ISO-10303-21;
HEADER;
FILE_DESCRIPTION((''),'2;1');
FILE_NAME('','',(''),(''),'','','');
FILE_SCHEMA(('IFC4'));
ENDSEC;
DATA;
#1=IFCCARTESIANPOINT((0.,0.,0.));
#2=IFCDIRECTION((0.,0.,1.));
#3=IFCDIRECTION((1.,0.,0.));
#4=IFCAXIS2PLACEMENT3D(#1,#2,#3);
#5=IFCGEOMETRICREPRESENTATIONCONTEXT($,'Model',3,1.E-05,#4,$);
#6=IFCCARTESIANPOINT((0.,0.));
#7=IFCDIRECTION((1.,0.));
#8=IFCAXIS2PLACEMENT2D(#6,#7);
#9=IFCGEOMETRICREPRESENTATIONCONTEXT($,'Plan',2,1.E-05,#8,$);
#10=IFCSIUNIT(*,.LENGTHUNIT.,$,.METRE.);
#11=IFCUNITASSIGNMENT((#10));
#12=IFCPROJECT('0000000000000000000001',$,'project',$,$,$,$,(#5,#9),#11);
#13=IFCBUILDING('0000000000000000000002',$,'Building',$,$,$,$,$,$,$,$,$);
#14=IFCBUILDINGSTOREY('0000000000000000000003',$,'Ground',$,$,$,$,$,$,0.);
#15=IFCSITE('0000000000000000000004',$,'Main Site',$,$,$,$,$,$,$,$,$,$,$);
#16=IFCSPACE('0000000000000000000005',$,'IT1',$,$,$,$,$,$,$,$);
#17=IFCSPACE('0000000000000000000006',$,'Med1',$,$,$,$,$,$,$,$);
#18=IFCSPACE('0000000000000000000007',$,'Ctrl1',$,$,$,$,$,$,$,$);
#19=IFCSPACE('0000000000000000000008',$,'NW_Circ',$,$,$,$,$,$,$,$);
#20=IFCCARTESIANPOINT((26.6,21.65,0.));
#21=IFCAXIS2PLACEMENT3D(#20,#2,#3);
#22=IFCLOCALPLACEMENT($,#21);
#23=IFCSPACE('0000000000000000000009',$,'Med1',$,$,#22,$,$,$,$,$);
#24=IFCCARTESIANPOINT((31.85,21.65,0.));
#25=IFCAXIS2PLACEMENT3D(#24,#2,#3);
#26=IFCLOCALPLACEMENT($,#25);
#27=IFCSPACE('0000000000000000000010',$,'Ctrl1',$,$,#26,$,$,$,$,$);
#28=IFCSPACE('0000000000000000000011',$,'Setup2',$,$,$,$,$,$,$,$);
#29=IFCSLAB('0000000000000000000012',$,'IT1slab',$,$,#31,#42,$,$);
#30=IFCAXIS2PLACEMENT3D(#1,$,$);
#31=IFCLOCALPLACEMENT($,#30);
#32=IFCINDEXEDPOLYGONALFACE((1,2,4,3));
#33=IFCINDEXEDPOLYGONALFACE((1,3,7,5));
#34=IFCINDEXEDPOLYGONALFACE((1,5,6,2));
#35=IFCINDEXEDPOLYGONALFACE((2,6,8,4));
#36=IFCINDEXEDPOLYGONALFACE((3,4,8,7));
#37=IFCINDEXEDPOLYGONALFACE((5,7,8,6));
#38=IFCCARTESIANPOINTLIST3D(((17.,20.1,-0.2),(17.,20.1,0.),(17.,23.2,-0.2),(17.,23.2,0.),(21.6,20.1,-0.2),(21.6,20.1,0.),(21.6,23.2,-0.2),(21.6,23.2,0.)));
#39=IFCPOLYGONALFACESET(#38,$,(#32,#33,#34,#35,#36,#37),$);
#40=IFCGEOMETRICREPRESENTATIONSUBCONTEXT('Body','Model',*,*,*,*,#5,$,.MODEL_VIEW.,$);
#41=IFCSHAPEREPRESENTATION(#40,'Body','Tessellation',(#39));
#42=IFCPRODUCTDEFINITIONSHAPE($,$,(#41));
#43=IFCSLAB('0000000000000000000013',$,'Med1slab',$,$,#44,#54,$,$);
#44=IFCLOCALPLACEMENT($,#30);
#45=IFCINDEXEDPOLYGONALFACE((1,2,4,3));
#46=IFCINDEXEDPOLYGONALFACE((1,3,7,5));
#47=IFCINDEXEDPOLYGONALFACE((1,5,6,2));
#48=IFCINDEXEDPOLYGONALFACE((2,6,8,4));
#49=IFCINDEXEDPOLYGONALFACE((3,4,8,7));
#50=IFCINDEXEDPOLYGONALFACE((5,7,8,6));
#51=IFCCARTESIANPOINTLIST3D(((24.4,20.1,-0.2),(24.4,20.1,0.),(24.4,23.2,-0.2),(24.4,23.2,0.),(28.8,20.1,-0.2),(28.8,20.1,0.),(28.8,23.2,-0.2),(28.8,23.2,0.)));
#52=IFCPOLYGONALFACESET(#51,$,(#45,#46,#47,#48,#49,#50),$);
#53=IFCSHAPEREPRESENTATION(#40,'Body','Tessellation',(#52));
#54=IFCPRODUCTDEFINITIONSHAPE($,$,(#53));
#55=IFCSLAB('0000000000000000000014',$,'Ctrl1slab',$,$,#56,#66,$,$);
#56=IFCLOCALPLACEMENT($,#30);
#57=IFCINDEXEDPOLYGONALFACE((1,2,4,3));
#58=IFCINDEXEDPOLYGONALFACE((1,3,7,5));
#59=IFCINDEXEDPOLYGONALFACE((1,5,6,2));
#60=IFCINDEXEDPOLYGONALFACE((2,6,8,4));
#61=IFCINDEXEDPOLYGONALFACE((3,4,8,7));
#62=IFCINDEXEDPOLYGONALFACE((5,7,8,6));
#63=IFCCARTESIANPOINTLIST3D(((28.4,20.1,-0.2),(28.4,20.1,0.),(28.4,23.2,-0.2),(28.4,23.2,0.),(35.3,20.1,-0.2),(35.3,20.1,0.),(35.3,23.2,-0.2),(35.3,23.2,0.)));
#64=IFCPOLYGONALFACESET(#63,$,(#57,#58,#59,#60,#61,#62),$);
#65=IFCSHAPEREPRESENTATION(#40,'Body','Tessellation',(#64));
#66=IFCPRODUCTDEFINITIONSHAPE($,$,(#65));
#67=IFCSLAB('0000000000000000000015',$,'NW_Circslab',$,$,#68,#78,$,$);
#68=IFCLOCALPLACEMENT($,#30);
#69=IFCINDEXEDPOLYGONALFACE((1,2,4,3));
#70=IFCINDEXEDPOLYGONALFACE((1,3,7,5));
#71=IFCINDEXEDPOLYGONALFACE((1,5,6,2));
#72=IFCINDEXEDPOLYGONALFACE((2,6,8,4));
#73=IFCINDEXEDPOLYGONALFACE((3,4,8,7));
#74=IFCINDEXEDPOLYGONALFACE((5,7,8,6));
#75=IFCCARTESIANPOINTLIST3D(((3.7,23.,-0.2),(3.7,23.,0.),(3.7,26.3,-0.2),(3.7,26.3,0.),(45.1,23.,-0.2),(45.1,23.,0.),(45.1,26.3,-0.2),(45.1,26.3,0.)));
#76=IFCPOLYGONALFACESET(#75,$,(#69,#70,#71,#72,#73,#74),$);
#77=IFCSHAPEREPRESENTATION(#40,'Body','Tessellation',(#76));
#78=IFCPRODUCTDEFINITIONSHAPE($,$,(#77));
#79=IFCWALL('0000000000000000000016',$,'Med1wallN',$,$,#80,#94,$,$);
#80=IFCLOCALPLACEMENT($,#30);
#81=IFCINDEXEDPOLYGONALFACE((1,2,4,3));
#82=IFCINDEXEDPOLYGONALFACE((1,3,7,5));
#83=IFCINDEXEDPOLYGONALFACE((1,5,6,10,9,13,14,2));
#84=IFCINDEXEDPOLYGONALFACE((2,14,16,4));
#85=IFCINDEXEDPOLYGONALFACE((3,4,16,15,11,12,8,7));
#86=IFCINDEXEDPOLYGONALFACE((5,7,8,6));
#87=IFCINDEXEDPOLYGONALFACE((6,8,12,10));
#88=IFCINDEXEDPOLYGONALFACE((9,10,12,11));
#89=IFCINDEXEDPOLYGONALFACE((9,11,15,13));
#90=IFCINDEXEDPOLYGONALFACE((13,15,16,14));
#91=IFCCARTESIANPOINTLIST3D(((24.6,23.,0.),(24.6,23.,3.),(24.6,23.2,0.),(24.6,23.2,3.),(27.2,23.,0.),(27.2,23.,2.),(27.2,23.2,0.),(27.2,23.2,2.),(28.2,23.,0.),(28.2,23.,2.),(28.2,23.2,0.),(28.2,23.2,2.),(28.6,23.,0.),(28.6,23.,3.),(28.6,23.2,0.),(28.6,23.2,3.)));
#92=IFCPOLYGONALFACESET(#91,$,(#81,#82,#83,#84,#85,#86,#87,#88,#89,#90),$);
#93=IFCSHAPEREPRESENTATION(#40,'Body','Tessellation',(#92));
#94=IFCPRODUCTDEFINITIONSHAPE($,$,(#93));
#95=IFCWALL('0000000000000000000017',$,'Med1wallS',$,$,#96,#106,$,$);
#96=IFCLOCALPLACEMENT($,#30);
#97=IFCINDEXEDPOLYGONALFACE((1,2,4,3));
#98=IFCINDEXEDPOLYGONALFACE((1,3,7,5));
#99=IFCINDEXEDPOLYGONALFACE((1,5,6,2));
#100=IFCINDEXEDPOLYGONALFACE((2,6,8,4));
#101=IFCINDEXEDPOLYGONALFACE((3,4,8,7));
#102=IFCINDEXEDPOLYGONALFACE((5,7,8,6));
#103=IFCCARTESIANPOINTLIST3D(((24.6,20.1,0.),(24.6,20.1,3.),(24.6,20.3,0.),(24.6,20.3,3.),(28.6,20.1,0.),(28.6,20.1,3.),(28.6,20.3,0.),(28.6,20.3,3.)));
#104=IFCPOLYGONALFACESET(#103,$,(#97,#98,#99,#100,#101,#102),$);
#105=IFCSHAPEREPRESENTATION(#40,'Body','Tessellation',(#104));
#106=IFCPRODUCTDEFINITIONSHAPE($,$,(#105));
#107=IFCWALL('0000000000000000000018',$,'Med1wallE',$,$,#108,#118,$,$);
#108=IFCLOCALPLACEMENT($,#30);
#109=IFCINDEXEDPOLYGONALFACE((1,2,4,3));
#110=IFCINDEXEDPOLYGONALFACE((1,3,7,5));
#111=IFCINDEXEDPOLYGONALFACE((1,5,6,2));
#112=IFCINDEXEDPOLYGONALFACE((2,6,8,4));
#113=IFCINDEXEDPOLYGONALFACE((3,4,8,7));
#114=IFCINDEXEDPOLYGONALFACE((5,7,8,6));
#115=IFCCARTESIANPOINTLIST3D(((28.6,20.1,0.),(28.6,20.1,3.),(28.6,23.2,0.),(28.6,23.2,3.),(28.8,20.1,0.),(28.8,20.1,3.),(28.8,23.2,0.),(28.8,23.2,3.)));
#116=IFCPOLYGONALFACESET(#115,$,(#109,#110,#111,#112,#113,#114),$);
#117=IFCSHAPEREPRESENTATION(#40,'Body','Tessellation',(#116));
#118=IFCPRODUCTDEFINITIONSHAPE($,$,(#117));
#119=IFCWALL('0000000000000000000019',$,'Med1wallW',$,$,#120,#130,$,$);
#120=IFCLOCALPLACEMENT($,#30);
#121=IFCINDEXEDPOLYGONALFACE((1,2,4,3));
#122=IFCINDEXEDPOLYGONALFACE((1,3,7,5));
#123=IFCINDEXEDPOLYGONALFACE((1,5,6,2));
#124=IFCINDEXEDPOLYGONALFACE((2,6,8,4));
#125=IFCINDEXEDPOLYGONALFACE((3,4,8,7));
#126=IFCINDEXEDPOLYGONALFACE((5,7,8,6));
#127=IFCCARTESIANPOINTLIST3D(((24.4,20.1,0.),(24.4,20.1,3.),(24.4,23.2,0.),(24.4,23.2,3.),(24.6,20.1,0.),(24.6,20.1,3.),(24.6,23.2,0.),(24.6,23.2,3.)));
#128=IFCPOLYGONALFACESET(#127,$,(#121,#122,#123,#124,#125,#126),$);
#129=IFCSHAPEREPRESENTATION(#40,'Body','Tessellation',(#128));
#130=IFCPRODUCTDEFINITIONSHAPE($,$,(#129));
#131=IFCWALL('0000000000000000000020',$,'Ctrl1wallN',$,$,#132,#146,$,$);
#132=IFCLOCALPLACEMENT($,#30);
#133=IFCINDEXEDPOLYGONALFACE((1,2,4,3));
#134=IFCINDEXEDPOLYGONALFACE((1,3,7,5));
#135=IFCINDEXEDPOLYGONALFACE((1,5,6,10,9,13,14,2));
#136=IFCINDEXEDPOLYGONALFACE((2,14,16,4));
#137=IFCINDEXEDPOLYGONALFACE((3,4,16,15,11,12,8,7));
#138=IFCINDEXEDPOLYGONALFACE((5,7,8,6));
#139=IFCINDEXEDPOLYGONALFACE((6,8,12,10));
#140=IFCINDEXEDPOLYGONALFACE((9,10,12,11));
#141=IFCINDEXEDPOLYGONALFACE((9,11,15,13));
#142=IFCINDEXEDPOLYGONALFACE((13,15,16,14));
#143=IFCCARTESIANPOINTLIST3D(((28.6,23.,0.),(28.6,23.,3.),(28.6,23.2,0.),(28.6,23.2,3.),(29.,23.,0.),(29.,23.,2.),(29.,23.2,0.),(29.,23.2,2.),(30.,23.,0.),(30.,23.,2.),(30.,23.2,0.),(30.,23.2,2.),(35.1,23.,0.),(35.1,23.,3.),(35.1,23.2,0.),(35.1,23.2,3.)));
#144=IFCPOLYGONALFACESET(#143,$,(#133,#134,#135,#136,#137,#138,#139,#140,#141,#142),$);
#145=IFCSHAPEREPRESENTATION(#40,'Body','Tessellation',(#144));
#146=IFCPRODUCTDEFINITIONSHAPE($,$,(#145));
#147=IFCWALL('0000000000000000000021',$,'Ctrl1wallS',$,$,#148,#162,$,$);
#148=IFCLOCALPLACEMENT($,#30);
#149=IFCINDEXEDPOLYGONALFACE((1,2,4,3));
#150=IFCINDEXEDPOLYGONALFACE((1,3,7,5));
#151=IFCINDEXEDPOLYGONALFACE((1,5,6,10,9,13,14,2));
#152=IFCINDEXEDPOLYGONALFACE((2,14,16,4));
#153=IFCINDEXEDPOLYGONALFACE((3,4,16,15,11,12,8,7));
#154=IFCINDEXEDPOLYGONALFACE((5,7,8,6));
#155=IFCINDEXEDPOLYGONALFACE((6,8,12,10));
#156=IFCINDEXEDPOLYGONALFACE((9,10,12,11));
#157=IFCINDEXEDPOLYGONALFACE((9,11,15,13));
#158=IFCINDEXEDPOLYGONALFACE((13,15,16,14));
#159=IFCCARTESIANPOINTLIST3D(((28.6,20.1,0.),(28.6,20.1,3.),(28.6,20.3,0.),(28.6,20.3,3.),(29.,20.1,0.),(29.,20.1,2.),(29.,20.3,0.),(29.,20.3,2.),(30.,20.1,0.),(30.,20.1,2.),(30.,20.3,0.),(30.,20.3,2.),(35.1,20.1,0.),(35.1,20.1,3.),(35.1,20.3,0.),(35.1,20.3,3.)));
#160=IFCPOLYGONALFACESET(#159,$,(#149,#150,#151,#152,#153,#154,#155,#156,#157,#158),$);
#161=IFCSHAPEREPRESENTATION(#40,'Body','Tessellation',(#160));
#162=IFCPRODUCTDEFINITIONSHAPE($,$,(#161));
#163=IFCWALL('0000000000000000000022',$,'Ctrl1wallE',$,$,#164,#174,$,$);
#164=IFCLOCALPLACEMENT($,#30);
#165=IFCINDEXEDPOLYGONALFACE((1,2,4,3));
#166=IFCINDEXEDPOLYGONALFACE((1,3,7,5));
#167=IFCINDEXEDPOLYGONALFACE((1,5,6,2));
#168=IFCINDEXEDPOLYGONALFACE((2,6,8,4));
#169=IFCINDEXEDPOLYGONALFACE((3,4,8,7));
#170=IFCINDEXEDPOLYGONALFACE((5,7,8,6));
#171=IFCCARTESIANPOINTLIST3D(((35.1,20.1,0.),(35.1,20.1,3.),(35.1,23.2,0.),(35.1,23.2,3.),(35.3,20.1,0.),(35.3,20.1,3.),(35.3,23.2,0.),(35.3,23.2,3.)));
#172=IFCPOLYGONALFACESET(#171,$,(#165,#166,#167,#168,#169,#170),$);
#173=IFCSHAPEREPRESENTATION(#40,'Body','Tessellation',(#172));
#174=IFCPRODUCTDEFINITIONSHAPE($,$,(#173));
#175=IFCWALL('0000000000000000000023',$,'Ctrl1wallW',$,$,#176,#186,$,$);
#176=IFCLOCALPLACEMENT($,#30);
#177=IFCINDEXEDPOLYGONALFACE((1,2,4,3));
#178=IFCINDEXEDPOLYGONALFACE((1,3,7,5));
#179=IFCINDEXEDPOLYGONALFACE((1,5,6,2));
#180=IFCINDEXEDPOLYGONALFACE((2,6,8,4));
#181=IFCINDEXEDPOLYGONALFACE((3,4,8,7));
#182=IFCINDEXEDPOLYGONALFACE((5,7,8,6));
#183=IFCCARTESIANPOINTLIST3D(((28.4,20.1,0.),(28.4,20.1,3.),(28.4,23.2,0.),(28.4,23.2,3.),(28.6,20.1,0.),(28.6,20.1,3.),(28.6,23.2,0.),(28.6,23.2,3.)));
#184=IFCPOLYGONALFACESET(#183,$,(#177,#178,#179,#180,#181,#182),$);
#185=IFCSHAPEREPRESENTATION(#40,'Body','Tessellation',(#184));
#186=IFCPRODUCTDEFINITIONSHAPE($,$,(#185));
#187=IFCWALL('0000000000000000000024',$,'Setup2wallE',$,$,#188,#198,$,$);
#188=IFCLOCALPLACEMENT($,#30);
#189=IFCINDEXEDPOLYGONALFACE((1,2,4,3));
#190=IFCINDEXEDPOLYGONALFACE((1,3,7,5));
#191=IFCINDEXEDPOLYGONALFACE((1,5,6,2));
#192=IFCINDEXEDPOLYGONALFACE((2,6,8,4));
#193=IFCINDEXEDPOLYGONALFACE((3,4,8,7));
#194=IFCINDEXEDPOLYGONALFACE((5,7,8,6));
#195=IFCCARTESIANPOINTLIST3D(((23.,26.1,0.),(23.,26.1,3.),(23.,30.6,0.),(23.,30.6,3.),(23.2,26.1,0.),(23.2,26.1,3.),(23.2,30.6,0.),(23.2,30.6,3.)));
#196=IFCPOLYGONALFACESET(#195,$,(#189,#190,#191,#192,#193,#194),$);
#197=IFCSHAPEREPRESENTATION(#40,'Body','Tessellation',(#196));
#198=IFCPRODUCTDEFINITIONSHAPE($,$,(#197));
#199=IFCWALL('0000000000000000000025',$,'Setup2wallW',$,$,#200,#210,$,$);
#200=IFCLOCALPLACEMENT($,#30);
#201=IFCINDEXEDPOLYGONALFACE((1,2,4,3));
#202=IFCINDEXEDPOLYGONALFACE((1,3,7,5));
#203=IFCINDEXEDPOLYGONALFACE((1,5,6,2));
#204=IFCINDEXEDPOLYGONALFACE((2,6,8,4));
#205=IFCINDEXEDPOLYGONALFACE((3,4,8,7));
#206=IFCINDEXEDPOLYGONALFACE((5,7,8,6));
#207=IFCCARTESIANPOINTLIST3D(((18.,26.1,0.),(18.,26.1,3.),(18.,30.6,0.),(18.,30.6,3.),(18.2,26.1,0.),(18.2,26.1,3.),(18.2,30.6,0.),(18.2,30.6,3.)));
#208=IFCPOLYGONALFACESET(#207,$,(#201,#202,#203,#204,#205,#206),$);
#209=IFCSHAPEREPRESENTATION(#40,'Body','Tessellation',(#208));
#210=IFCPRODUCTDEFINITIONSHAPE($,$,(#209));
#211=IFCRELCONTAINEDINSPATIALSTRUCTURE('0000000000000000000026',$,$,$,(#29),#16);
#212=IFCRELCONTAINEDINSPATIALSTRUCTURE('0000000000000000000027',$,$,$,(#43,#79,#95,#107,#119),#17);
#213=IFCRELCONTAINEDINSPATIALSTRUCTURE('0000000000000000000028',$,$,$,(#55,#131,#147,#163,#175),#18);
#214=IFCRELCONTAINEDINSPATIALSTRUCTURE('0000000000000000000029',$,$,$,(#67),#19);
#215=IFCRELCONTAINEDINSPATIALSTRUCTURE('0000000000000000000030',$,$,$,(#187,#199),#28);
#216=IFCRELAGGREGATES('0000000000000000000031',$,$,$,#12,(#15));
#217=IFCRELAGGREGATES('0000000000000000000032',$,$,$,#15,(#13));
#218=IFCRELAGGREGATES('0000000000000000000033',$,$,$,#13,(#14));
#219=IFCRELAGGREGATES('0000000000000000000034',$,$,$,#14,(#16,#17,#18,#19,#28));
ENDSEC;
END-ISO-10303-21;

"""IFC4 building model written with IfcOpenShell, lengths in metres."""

from ifc_helpers import new_model, si_unit, frame, origin_with_axes, origin_2d_with_axis, place, context, subcontext, project, spatial, indexed_curve, rectangle, outline, extrude, element, save


model = new_model("IFC4")

# Units and contexts
model_context = context("Model", 3, precision=1e-05, world=origin_with_axes())
plan_context = context("Plan", 2, precision=1e-05, world=origin_2d_with_axis())
body_context = subcontext(model_context, "Body", "Model", "MODEL_VIEW")
ifc_project = project(units=[si_unit("LENGTHUNIT", "METRE")], contexts=[model_context, plan_context])

# Site, building, storey, space
site = spatial("IfcSite", under=ifc_project, Name="Main Site")
building = spatial("IfcBuilding", under=site, Name="Building")
storey = spatial("IfcBuildingStorey", under=building, Name="Ground", Elevation=0.0)
space_1 = spatial("IfcSpace", under=storey, Name="IT1")

# Slab
slab_1_placement = place(None, frame((19.3, 21.65, -0.2), z_axis=(0.0, 0.0, 1.0), x_axis=(1.0, 0.0, 0.0)))
element("IfcSlab", 1, at=slab_1_placement, inside=space_1, Name="IT1slab", context=body_context, shape_type="SweptSolid", body=[
    extrude(rectangle(XDim=4.6, YDim=3.1), origin_with_axes(), (0.0, 0.0, 1.0), 0.2),
])

# Shared definitions
space_2 = spatial("IfcSpace", under=storey, Name="Med1")

# Slab
slab_2_placement = place(None, frame((26.6, 21.65, -0.2), z_axis=(0.0, 0.0, 1.0), x_axis=(1.0, 0.0, 0.0)))
element("IfcSlab", 2, at=slab_2_placement, inside=space_2, Name="Med1slab", context=body_context, shape_type="SweptSolid", body=[
    extrude(rectangle(XDim=4.4, YDim=3.1), origin_with_axes(), (0.0, 0.0, 1.0), 0.2),
])

# Shared definitions
space_3 = spatial("IfcSpace", under=storey, Name="Ctrl1")

# Slab
slab_3_placement = place(None, frame((31.85, 21.65, -0.2), z_axis=(0.0, 0.0, 1.0), x_axis=(1.0, 0.0, 0.0)))
element("IfcSlab", 3, at=slab_3_placement, inside=space_3, Name="Ctrl1slab", context=body_context, shape_type="SweptSolid", body=[
    extrude(rectangle(XDim=6.9, YDim=3.1), origin_with_axes(), (0.0, 0.0, 1.0), 0.2),
])

# Shared definitions
space_4 = spatial("IfcSpace", under=storey, Name="NW_Circ")

# Slab
slab_4_placement = place(None, frame((24.4, 24.65, -0.2), z_axis=(0.0, 0.0, 1.0), x_axis=(1.0, 0.0, 0.0)))
element("IfcSlab", 4, at=slab_4_placement, inside=space_4, Name="NW_Circslab", context=body_context, shape_type="SweptSolid", body=[
    extrude(rectangle(XDim=41.4, YDim=3.3), origin_with_axes(), (0.0, 0.0, 1.0), 0.2),
])

# Wall
wall_1_placement = place(None, frame((24.6, 23.0, 0.0), z_axis=(0.0, 0.0, 1.0), x_axis=(1.0, 0.0, 0.0)))
wall_1 = element("IfcWall", 5, at=wall_1_placement, inside=space_2, Name="Med1wallN", context=body_context, shape_type="SweptSolid", body=[
    extrude(outline(indexed_curve([(0.0, 0.0), (0.0, 0.2), (4.0, 0.2), (4.0, 0.0), (0.0, 0.0)], self_intersect=False)), origin_with_axes(), (0.0, 0.0, 1.0), 3.0),
])

# Shared definitions
space_5_placement = place(None, frame((26.6, 21.65, 0.0), z_axis=(0.0, 0.0, 1.0), x_axis=(1.0, 0.0, 0.0)))
space_5 = spatial("IfcSpace", at=space_5_placement, Name="Med1")

# Opening
opening_1_placement = place(wall_1_placement, frame((2.6, 0.0, 0.0), z_axis=(0.0, 0.0, 1.0), x_axis=(1.0, 0.0, 0.0)))
element("IfcOpeningElement", 6, at=opening_1_placement, inside=space_5, cuts=wall_1, context=body_context, shape_type="SweptSolid", body=[
    extrude(outline(indexed_curve([(0.0, 0.0), (0.0, 0.4), (1.0, 0.4), (1.0, 0.0), (0.0, 0.0)], self_intersect=False)), origin_with_axes(), (0.0, 0.0, 1.0), 2.0),
])

# Walls
wall_2_placement = place(None, frame((24.6, 20.1, 0.0), z_axis=(0.0, 0.0, 1.0), x_axis=(1.0, 0.0, 0.0)))
element("IfcWall", 7, at=wall_2_placement, inside=space_2, Name="Med1wallS", context=body_context, shape_type="SweptSolid", body=[
    extrude(outline(indexed_curve([(0.0, 0.0), (0.0, 0.2), (4.0, 0.2), (4.0, 0.0), (0.0, 0.0)], self_intersect=False)), origin_with_axes(), (0.0, 0.0, 1.0), 3.0),
])
for number, where, z_axis, x_axis, name in (
    (8, (28.8, 20.1, 0.0), (0.0, 0.0, 1.0), (0.0, 1.0, 0.0), "Med1wallE"),
    (9, (24.6, 20.1, 0.0), (0.0, 0.0, 1.0), (0.0, 1.0, 0.0), "Med1wallW"),
):
    element("IfcWall", number, at=place(None, frame(where, z_axis=z_axis, x_axis=x_axis)), inside=space_2, Name=name, context=body_context, shape_type="SweptSolid", body=[
        extrude(outline(indexed_curve([(0.0, 0.0), (0.0, 0.2), (3.1, 0.2), (3.1, 0.0), (0.0, 0.0)], self_intersect=False)), origin_with_axes(), (0.0, 0.0, 1.0), 3.0),
    ])

# Wall
wall_3_placement = place(None, frame((28.6, 23.0, 0.0), z_axis=(0.0, 0.0, 1.0), x_axis=(1.0, 0.0, 0.0)))
wall_3 = element("IfcWall", 10, at=wall_3_placement, inside=space_3, Name="Ctrl1wallN", context=body_context, shape_type="SweptSolid", body=[
    extrude(outline(indexed_curve([(0.0, 0.0), (0.0, 0.2), (6.5, 0.2), (6.5, 0.0), (0.0, 0.0)], self_intersect=False)), origin_with_axes(), (0.0, 0.0, 1.0), 3.0),
])

# Shared definitions
space_6_placement = place(None, frame((31.85, 21.65, 0.0), z_axis=(0.0, 0.0, 1.0), x_axis=(1.0, 0.0, 0.0)))
space_6 = spatial("IfcSpace", at=space_6_placement, Name="Ctrl1")

# Opening
opening_2_placement = place(wall_3_placement, frame((0.4, 0.0, 0.0), z_axis=(0.0, 0.0, 1.0), x_axis=(1.0, 0.0, 0.0)))
element("IfcOpeningElement", 11, at=opening_2_placement, inside=space_6, cuts=wall_3, context=body_context, shape_type="SweptSolid", body=[
    extrude(outline(indexed_curve([(0.0, 0.0), (0.0, 0.4), (1.0, 0.4), (1.0, 0.0), (0.0, 0.0)], self_intersect=False)), origin_with_axes(), (0.0, 0.0, 1.0), 2.0),
])

# Wall, opening
wall_4_placement = place(None, frame((28.6, 20.1, 0.0), z_axis=(0.0, 0.0, 1.0), x_axis=(1.0, 0.0, 0.0)))
wall_4 = element("IfcWall", 12, at=wall_4_placement, inside=space_3, Name="Ctrl1wallS", context=body_context, shape_type="SweptSolid", body=[
    extrude(outline(indexed_curve([(0.0, 0.0), (0.0, 0.2), (6.5, 0.2), (6.5, 0.0), (0.0, 0.0)], self_intersect=False)), origin_with_axes(), (0.0, 0.0, 1.0), 3.0),
])
opening_3_placement = place(wall_4_placement, frame((0.4, 0.0, 0.0), z_axis=(0.0, 0.0, 1.0), x_axis=(1.0, 0.0, 0.0)))
element("IfcOpeningElement", 13, at=opening_3_placement, inside=space_6, cuts=wall_4, context=body_context, shape_type="SweptSolid", body=[
    extrude(outline(indexed_curve([(0.0, 0.0), (0.0, 0.4), (1.0, 0.4), (1.0, 0.0), (0.0, 0.0)], self_intersect=False)), origin_with_axes(), (0.0, 0.0, 1.0), 2.0),
])

# Walls
for number, where, z_axis, x_axis, name in (
    (14, (35.3, 20.1, 0.0), (0.0, 0.0, 1.0), (0.0, 1.0, 0.0), "Ctrl1wallE"),
    (15, (28.6, 20.1, 0.0), (0.0, 0.0, 1.0), (0.0, 1.0, 0.0), "Ctrl1wallW"),
):
    element("IfcWall", number, at=place(None, frame(where, z_axis=z_axis, x_axis=x_axis)), inside=space_3, Name=name, context=body_context, shape_type="SweptSolid", body=[
        extrude(outline(indexed_curve([(0.0, 0.0), (0.0, 0.2), (3.1, 0.2), (3.1, 0.0), (0.0, 0.0)], self_intersect=False)), origin_with_axes(), (0.0, 0.0, 1.0), 3.0),
    ])

# Shared definitions
space_7 = spatial("IfcSpace", under=storey, Name="Setup2")

# Walls
for number, where, z_axis, x_axis, name in (
    (16, (23.2, 26.1, 0.0), (0.0, 0.0, 1.0), (0.0, 1.0, 0.0), "Setup2wallE"),
    (17, (18.2, 26.1, 0.0), (0.0, 0.0, 1.0), (0.0, 1.0, 0.0), "Setup2wallW"),
):
    element("IfcWall", number, at=place(None, frame(where, z_axis=z_axis, x_axis=x_axis)), inside=space_7, Name=name, context=body_context, shape_type="SweptSolid", body=[
        extrude(outline(indexed_curve([(0.0, 0.0), (0.0, 0.2), (4.5, 0.2), (4.5, 0.0), (0.0, 0.0)], self_intersect=False)), origin_with_axes(), (0.0, 0.0, 1.0), 3.0),
    ])

save(model, "model.ifc")
